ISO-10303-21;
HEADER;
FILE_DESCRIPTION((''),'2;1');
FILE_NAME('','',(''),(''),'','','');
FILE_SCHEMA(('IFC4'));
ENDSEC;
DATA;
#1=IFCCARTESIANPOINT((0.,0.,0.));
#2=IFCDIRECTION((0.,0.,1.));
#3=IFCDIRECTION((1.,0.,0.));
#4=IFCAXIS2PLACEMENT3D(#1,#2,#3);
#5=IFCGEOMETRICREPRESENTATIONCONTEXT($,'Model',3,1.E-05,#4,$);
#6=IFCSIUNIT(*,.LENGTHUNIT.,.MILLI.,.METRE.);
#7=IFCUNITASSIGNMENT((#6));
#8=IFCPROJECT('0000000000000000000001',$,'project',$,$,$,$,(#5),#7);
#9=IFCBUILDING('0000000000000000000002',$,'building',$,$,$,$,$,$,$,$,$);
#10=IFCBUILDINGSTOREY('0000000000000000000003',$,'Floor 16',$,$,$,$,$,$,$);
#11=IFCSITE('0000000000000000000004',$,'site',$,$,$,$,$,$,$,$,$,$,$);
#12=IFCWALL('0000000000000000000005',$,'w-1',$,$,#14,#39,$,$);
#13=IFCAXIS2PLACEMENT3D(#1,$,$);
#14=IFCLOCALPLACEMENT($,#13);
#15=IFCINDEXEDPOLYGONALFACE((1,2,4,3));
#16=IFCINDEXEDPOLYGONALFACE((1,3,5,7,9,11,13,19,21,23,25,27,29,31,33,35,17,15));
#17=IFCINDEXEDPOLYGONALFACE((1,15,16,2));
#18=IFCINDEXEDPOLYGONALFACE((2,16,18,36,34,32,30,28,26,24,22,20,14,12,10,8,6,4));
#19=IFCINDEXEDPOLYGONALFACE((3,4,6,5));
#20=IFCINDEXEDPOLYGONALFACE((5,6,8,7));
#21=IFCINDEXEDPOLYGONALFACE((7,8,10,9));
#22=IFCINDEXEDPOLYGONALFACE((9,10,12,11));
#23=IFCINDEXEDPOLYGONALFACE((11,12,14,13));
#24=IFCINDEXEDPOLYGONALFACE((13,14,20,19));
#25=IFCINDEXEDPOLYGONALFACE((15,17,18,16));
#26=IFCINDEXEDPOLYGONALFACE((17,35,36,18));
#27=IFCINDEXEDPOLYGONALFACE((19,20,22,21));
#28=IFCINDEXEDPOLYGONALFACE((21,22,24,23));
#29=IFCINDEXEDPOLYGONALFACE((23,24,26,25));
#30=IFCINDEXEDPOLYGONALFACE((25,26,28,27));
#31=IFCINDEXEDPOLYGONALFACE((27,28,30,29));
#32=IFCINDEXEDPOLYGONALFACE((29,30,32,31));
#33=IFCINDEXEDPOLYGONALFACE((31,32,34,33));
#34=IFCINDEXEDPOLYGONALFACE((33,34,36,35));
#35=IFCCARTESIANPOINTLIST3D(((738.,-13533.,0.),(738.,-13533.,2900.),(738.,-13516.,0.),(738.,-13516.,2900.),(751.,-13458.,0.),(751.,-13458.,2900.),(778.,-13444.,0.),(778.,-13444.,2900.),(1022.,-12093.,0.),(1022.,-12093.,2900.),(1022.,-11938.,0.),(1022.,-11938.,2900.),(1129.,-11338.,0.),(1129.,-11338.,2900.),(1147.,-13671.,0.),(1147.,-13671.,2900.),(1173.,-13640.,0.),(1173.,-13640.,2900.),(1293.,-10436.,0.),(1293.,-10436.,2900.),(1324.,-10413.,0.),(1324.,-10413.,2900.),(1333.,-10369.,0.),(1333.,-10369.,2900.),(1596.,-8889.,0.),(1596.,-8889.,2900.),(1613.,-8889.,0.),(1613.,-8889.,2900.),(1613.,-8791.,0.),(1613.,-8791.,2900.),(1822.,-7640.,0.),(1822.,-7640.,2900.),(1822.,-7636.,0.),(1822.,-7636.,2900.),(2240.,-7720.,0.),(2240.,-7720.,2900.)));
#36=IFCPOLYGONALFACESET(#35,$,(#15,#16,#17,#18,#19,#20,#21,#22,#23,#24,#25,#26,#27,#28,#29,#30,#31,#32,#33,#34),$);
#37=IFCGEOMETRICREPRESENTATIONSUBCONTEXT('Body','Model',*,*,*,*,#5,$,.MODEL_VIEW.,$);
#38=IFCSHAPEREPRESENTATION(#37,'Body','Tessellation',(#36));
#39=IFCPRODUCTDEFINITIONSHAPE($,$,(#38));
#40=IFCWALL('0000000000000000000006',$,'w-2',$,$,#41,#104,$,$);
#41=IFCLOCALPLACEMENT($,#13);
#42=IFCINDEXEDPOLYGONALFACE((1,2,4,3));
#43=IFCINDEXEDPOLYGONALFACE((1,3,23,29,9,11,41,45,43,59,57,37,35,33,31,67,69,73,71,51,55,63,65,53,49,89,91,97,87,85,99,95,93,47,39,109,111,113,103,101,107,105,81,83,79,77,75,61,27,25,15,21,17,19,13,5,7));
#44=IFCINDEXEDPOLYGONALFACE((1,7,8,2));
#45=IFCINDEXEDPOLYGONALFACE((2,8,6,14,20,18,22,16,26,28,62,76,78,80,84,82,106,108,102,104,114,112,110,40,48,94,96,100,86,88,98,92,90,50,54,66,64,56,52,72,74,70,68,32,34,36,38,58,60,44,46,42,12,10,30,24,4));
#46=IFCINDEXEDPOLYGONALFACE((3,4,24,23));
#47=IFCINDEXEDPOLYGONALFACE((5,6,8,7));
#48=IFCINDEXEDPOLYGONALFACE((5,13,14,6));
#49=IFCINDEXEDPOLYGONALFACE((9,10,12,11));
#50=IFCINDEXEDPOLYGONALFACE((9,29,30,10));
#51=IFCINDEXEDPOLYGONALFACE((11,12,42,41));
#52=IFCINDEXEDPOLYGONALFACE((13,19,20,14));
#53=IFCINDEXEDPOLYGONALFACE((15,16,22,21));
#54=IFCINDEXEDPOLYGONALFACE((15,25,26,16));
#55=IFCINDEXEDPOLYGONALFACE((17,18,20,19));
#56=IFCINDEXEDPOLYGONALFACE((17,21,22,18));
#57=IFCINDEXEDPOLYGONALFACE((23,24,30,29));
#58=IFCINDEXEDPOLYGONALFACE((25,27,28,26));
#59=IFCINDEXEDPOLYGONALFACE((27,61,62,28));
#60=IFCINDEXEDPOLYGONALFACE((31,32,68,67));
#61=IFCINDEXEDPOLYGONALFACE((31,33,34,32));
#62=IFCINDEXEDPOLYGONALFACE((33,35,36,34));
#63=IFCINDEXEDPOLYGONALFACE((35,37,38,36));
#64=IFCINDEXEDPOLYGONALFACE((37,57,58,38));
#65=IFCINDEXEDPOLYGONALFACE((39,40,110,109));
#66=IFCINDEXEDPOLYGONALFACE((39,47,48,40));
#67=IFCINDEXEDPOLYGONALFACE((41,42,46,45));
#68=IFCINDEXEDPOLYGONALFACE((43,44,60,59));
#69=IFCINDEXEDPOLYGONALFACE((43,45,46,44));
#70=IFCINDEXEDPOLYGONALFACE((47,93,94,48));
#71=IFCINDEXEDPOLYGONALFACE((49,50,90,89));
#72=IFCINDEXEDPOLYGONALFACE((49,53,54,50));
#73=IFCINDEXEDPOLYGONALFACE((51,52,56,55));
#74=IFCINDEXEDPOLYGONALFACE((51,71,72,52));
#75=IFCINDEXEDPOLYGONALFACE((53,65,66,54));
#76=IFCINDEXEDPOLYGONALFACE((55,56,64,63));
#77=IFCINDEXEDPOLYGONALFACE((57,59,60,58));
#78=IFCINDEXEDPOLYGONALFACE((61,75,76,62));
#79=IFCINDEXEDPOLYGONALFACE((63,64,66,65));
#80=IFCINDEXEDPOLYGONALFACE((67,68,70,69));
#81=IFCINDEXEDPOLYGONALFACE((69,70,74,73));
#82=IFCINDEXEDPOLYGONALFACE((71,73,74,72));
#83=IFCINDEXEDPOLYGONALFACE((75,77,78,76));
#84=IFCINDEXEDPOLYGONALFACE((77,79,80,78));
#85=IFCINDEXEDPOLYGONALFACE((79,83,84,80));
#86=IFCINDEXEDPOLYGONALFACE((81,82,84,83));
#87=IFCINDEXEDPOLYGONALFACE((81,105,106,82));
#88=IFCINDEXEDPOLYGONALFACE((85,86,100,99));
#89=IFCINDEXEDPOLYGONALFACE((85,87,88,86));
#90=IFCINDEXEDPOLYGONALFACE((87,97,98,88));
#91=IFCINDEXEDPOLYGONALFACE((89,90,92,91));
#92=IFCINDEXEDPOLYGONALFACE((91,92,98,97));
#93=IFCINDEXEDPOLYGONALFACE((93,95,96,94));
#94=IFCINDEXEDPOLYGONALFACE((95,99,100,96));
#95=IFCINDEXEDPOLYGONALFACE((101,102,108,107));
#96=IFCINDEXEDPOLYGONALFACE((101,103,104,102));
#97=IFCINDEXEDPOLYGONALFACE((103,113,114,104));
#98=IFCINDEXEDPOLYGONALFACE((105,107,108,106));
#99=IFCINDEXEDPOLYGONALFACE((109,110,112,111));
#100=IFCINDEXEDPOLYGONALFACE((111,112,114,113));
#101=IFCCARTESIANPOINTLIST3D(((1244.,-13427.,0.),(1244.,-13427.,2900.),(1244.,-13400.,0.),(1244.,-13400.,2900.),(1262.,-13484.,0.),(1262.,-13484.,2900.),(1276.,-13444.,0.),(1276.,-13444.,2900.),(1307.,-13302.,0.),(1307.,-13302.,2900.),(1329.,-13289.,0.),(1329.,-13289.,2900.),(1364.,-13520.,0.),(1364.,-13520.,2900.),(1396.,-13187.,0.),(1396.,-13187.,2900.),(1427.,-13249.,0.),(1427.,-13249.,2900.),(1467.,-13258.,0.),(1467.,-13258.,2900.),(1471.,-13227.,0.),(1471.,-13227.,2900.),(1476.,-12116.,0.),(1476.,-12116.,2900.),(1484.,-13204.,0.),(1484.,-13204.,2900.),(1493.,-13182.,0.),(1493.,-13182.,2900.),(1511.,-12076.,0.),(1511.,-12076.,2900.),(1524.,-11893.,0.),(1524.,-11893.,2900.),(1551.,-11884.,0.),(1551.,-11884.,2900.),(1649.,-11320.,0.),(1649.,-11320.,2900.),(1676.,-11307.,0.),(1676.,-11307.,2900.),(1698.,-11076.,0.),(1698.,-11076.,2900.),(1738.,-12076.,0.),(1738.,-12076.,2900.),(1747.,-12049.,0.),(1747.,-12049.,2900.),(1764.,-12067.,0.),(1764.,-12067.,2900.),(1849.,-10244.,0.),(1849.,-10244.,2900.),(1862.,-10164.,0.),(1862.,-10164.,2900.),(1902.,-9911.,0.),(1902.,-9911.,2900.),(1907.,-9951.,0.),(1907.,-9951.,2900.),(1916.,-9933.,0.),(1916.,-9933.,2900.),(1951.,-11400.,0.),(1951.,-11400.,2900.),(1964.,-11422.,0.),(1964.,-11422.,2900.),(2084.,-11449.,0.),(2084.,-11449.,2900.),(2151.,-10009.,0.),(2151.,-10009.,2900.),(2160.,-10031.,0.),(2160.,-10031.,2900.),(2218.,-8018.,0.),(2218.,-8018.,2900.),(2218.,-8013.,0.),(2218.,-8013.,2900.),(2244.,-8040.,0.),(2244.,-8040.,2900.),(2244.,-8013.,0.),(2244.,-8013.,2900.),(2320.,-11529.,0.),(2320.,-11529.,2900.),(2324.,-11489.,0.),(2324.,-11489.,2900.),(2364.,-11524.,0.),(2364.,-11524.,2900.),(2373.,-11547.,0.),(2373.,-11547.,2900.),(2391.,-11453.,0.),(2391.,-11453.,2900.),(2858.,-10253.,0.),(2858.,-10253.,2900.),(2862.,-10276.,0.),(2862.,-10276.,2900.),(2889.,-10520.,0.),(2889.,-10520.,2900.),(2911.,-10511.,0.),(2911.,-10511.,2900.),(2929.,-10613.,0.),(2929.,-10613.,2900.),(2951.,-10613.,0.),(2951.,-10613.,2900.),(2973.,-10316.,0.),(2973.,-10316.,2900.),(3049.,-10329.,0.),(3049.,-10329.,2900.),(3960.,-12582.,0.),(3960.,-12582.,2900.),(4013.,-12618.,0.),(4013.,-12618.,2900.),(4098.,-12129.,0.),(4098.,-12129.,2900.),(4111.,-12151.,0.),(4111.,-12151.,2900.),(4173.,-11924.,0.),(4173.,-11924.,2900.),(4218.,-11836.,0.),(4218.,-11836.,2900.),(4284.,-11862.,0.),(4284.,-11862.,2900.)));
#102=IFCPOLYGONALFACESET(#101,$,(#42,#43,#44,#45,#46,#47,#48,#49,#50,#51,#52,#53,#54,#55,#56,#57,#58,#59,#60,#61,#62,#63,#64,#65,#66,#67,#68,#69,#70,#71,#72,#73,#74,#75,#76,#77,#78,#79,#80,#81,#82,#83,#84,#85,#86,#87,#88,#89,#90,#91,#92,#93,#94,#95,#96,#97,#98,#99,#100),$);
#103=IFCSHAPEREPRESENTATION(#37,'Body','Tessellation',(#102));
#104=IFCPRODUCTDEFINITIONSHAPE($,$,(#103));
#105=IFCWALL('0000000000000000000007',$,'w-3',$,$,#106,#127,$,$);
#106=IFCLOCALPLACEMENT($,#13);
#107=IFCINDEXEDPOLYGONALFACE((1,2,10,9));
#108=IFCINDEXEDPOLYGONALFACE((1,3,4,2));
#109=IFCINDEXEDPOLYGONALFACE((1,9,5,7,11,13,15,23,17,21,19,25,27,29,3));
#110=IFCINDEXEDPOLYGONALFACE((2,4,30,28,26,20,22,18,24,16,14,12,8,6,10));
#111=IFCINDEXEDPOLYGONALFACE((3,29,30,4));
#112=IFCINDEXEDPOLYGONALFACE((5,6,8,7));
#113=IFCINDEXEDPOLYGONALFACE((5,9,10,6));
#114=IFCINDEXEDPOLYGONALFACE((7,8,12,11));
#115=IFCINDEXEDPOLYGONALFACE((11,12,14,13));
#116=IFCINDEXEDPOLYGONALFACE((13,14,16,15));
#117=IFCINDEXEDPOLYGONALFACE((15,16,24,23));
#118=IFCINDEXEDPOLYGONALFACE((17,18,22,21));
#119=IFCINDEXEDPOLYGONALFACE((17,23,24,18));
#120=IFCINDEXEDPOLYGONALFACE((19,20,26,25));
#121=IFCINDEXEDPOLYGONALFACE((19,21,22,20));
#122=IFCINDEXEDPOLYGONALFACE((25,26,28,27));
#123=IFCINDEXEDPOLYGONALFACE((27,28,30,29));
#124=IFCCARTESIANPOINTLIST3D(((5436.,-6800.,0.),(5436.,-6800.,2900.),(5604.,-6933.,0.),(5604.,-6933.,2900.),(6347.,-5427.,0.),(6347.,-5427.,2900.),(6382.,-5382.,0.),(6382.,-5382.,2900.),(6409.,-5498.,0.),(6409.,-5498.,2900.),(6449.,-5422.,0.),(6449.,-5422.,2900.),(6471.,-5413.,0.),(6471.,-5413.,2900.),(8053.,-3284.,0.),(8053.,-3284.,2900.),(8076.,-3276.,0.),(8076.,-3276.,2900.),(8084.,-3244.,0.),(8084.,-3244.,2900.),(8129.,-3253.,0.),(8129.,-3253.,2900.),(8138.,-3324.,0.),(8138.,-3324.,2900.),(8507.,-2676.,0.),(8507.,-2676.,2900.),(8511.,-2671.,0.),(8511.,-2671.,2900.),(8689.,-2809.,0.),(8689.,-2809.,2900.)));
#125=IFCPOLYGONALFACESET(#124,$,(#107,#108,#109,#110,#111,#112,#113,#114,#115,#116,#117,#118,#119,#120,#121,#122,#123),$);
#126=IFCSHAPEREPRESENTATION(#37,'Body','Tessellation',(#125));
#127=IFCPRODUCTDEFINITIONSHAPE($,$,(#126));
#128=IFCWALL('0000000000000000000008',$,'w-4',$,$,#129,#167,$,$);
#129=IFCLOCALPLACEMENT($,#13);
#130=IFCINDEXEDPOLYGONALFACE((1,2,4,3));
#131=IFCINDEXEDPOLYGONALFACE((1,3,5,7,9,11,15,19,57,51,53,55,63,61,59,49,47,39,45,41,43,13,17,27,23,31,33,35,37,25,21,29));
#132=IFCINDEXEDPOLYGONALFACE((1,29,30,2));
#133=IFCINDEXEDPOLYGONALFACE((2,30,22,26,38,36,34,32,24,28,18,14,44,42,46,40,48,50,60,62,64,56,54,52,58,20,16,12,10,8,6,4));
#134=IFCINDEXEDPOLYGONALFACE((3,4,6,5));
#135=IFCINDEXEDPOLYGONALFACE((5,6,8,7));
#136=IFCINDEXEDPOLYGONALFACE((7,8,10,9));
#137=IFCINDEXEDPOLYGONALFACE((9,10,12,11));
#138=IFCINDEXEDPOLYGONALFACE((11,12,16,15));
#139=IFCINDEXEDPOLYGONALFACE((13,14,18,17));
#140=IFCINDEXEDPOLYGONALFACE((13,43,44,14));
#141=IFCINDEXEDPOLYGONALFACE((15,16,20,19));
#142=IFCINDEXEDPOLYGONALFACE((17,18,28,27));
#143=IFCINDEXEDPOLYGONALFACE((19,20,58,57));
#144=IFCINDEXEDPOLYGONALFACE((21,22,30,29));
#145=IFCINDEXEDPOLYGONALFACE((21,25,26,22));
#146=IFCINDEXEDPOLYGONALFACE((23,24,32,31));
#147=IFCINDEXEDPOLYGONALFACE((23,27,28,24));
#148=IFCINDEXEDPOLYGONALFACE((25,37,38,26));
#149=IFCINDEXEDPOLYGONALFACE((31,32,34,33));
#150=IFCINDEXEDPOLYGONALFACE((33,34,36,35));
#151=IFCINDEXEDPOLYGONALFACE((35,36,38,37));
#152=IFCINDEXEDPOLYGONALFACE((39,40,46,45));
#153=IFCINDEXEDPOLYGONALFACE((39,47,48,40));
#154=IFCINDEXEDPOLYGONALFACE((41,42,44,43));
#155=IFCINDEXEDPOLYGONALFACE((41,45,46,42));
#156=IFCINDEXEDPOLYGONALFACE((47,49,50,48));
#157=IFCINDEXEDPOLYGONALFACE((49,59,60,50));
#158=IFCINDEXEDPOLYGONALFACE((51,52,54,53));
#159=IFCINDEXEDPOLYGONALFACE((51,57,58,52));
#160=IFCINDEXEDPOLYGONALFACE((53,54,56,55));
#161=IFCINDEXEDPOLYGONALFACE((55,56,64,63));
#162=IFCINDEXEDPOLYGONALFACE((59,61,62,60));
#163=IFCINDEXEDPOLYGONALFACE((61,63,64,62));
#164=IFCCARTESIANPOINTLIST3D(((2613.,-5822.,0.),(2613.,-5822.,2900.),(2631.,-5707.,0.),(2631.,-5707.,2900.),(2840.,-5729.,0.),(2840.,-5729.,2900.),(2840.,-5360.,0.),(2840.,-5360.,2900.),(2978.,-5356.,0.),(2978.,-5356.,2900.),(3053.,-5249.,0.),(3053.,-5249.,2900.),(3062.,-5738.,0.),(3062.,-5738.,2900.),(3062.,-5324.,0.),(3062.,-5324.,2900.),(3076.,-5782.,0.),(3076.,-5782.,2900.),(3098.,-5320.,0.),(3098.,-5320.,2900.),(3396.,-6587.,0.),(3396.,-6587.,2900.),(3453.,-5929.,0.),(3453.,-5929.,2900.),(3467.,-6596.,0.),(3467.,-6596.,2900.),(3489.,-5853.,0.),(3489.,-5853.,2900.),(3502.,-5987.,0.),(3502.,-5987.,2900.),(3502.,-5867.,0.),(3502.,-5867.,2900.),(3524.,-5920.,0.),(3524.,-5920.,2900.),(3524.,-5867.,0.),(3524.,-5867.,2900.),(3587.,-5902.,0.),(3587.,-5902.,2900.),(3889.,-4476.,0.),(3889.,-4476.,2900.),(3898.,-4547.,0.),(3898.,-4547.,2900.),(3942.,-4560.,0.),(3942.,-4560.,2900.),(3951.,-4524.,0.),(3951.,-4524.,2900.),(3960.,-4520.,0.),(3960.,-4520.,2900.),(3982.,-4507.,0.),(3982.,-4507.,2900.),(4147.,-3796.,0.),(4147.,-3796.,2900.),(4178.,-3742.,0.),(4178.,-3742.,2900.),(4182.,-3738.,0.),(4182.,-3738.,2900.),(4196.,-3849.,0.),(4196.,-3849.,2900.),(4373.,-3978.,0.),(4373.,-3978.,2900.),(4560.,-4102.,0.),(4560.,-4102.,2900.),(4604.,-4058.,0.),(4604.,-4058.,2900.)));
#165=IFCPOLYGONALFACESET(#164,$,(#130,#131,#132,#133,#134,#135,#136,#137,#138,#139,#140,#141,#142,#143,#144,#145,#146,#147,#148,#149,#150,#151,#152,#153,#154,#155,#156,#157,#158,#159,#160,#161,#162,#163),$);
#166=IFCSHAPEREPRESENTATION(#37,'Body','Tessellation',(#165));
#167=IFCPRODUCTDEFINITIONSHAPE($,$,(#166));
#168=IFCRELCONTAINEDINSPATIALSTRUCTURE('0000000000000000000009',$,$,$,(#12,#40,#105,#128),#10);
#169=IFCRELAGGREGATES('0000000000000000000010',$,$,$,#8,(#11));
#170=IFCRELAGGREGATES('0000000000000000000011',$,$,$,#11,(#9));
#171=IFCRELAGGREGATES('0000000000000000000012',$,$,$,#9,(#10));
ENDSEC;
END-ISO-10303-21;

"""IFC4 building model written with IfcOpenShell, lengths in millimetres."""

from ifc_helpers import new_model, si_unit, origin_with_axes, place, context, subcontext, project, spatial, indexed_curve, outline, extrude, element, save


model = new_model("IFC4")

# Units and contexts
model_context = context("Model", 3, precision=1e-05, world=origin_with_axes())
body_context = subcontext(model_context, "Body", "Model", "MODEL_VIEW")
ifc_project = project(units=[si_unit("LENGTHUNIT", "METRE", prefix="MILLI")], contexts=[model_context])

# Site, building, storey
site = spatial("IfcSite", under=ifc_project, Name="site")
building = spatial("IfcBuilding", under=site, Name="building")
storey = spatial("IfcBuildingStorey", under=building, Name="Floor 16")

# Walls
wall_1_placement = place(None, origin_with_axes())
element("IfcWall", 1, at=wall_1_placement, inside=storey, Name="w-1", context=body_context, shape_type="SweptSolid", body=[
    extrude(outline(indexed_curve([(1822.0, -7636.0), (1822.0, -7640.0), (1613.0, -8791.0), (1613.0, -8889.0), (1596.0, -8889.0), (1333.0, -10369.0), (1324.0, -10413.0), (1293.0, -10436.0), (1129.0, -11338.0), (1022.0, -11938.0), (1022.0, -12093.0), (778.0, -13444.0), (751.0, -13458.0), (738.0, -13516.0), (738.0, -13533.0), (1147.0, -13671.0), (1173.0, -13640.0), (2240.0, -7720.0)])), None, (0.0, 0.0, 1.0), 2900.0),
])
wall_2_placement = place(None, origin_with_axes())
element("IfcWall", 2, at=wall_2_placement, inside=storey, Name="w-2", context=body_context, shape_type="SweptSolid", body=[
    extrude(outline(indexed_curve([(2218.0, -8013.0), (2218.0, -8018.0), (1524.0, -11893.0), (1551.0, -11884.0), (1649.0, -11320.0), (1676.0, -11307.0), (1951.0, -11400.0), (1964.0, -11422.0), (1747.0, -12049.0), (1764.0, -12067.0), (1738.0, -12076.0), (1329.0, -13289.0), (1307.0, -13302.0), (1511.0, -12076.0), (1476.0, -12116.0), (1244.0, -13400.0), (1244.0, -13427.0), (1276.0, -13444.0), (1262.0, -13484.0), (1364.0, -13520.0), (1467.0, -13258.0), (1427.0, -13249.0), (1471.0, -13227.0), (1396.0, -13187.0), (1484.0, -13204.0), (1493.0, -13182.0), (2084.0, -11449.0), (2320.0, -11529.0), (2324.0, -11489.0), (2364.0, -11524.0), (2391.0, -11453.0), (2373.0, -11547.0), (4098.0, -12129.0), (4111.0, -12151.0), (3960.0, -12582.0), (4013.0, -12618.0), (4284.0, -11862.0), (4218.0, -11836.0), (4173.0, -11924.0), (1698.0, -11076.0), (1849.0, -10244.0), (2929.0, -10613.0), (2951.0, -10613.0), (3049.0, -10329.0), (2858.0, -10253.0), (2862.0, -10276.0), (2973.0, -10316.0), (2911.0, -10511.0), (2889.0, -10520.0), (1862.0, -10164.0), (1907.0, -9951.0), (2160.0, -10031.0), (2151.0, -10009.0), (1916.0, -9933.0), (1902.0, -9911.0), (2244.0, -8040.0), (2244.0, -8013.0)])), None, (0.0, 0.0, 1.0), 2900.0),
])
wall_3_placement = place(None, origin_with_axes())
element("IfcWall", 3, at=wall_3_placement, inside=storey, Name="w-3", context=body_context, shape_type="SweptSolid", body=[
    extrude(outline(indexed_curve([(8511.0, -2671.0), (8507.0, -2676.0), (8084.0, -3244.0), (8129.0, -3253.0), (8076.0, -3276.0), (8138.0, -3324.0), (8053.0, -3284.0), (6471.0, -5413.0), (6449.0, -5422.0), (6382.0, -5382.0), (6347.0, -5427.0), (6409.0, -5498.0), (5436.0, -6800.0), (5604.0, -6933.0), (8689.0, -2809.0)])), None, (0.0, 0.0, 1.0), 2900.0),
])
wall_4_placement = place(None, origin_with_axes())
element("IfcWall", 4, at=wall_4_placement, inside=storey, Name="w-4", context=body_context, shape_type="SweptSolid", body=[
    extrude(outline(indexed_curve([(4182.0, -3738.0), (4178.0, -3742.0), (4147.0, -3796.0), (4196.0, -3849.0), (3098.0, -5320.0), (3062.0, -5324.0), (3053.0, -5249.0), (2978.0, -5356.0), (2840.0, -5360.0), (2840.0, -5729.0), (2631.0, -5707.0), (2613.0, -5822.0), (3502.0, -5987.0), (3396.0, -6587.0), (3467.0, -6596.0), (3587.0, -5902.0), (3524.0, -5867.0), (3524.0, -5920.0), (3502.0, -5867.0), (3453.0, -5929.0), (3489.0, -5853.0), (3076.0, -5782.0), (3062.0, -5738.0), (3942.0, -4560.0), (3898.0, -4547.0), (3951.0, -4524.0), (3889.0, -4476.0), (3960.0, -4520.0), (3982.0, -4507.0), (4373.0, -3978.0), (4560.0, -4102.0), (4604.0, -4058.0)])), None, (0.0, 0.0, 1.0), 2900.0),
])

save(model, "model.ifc")
